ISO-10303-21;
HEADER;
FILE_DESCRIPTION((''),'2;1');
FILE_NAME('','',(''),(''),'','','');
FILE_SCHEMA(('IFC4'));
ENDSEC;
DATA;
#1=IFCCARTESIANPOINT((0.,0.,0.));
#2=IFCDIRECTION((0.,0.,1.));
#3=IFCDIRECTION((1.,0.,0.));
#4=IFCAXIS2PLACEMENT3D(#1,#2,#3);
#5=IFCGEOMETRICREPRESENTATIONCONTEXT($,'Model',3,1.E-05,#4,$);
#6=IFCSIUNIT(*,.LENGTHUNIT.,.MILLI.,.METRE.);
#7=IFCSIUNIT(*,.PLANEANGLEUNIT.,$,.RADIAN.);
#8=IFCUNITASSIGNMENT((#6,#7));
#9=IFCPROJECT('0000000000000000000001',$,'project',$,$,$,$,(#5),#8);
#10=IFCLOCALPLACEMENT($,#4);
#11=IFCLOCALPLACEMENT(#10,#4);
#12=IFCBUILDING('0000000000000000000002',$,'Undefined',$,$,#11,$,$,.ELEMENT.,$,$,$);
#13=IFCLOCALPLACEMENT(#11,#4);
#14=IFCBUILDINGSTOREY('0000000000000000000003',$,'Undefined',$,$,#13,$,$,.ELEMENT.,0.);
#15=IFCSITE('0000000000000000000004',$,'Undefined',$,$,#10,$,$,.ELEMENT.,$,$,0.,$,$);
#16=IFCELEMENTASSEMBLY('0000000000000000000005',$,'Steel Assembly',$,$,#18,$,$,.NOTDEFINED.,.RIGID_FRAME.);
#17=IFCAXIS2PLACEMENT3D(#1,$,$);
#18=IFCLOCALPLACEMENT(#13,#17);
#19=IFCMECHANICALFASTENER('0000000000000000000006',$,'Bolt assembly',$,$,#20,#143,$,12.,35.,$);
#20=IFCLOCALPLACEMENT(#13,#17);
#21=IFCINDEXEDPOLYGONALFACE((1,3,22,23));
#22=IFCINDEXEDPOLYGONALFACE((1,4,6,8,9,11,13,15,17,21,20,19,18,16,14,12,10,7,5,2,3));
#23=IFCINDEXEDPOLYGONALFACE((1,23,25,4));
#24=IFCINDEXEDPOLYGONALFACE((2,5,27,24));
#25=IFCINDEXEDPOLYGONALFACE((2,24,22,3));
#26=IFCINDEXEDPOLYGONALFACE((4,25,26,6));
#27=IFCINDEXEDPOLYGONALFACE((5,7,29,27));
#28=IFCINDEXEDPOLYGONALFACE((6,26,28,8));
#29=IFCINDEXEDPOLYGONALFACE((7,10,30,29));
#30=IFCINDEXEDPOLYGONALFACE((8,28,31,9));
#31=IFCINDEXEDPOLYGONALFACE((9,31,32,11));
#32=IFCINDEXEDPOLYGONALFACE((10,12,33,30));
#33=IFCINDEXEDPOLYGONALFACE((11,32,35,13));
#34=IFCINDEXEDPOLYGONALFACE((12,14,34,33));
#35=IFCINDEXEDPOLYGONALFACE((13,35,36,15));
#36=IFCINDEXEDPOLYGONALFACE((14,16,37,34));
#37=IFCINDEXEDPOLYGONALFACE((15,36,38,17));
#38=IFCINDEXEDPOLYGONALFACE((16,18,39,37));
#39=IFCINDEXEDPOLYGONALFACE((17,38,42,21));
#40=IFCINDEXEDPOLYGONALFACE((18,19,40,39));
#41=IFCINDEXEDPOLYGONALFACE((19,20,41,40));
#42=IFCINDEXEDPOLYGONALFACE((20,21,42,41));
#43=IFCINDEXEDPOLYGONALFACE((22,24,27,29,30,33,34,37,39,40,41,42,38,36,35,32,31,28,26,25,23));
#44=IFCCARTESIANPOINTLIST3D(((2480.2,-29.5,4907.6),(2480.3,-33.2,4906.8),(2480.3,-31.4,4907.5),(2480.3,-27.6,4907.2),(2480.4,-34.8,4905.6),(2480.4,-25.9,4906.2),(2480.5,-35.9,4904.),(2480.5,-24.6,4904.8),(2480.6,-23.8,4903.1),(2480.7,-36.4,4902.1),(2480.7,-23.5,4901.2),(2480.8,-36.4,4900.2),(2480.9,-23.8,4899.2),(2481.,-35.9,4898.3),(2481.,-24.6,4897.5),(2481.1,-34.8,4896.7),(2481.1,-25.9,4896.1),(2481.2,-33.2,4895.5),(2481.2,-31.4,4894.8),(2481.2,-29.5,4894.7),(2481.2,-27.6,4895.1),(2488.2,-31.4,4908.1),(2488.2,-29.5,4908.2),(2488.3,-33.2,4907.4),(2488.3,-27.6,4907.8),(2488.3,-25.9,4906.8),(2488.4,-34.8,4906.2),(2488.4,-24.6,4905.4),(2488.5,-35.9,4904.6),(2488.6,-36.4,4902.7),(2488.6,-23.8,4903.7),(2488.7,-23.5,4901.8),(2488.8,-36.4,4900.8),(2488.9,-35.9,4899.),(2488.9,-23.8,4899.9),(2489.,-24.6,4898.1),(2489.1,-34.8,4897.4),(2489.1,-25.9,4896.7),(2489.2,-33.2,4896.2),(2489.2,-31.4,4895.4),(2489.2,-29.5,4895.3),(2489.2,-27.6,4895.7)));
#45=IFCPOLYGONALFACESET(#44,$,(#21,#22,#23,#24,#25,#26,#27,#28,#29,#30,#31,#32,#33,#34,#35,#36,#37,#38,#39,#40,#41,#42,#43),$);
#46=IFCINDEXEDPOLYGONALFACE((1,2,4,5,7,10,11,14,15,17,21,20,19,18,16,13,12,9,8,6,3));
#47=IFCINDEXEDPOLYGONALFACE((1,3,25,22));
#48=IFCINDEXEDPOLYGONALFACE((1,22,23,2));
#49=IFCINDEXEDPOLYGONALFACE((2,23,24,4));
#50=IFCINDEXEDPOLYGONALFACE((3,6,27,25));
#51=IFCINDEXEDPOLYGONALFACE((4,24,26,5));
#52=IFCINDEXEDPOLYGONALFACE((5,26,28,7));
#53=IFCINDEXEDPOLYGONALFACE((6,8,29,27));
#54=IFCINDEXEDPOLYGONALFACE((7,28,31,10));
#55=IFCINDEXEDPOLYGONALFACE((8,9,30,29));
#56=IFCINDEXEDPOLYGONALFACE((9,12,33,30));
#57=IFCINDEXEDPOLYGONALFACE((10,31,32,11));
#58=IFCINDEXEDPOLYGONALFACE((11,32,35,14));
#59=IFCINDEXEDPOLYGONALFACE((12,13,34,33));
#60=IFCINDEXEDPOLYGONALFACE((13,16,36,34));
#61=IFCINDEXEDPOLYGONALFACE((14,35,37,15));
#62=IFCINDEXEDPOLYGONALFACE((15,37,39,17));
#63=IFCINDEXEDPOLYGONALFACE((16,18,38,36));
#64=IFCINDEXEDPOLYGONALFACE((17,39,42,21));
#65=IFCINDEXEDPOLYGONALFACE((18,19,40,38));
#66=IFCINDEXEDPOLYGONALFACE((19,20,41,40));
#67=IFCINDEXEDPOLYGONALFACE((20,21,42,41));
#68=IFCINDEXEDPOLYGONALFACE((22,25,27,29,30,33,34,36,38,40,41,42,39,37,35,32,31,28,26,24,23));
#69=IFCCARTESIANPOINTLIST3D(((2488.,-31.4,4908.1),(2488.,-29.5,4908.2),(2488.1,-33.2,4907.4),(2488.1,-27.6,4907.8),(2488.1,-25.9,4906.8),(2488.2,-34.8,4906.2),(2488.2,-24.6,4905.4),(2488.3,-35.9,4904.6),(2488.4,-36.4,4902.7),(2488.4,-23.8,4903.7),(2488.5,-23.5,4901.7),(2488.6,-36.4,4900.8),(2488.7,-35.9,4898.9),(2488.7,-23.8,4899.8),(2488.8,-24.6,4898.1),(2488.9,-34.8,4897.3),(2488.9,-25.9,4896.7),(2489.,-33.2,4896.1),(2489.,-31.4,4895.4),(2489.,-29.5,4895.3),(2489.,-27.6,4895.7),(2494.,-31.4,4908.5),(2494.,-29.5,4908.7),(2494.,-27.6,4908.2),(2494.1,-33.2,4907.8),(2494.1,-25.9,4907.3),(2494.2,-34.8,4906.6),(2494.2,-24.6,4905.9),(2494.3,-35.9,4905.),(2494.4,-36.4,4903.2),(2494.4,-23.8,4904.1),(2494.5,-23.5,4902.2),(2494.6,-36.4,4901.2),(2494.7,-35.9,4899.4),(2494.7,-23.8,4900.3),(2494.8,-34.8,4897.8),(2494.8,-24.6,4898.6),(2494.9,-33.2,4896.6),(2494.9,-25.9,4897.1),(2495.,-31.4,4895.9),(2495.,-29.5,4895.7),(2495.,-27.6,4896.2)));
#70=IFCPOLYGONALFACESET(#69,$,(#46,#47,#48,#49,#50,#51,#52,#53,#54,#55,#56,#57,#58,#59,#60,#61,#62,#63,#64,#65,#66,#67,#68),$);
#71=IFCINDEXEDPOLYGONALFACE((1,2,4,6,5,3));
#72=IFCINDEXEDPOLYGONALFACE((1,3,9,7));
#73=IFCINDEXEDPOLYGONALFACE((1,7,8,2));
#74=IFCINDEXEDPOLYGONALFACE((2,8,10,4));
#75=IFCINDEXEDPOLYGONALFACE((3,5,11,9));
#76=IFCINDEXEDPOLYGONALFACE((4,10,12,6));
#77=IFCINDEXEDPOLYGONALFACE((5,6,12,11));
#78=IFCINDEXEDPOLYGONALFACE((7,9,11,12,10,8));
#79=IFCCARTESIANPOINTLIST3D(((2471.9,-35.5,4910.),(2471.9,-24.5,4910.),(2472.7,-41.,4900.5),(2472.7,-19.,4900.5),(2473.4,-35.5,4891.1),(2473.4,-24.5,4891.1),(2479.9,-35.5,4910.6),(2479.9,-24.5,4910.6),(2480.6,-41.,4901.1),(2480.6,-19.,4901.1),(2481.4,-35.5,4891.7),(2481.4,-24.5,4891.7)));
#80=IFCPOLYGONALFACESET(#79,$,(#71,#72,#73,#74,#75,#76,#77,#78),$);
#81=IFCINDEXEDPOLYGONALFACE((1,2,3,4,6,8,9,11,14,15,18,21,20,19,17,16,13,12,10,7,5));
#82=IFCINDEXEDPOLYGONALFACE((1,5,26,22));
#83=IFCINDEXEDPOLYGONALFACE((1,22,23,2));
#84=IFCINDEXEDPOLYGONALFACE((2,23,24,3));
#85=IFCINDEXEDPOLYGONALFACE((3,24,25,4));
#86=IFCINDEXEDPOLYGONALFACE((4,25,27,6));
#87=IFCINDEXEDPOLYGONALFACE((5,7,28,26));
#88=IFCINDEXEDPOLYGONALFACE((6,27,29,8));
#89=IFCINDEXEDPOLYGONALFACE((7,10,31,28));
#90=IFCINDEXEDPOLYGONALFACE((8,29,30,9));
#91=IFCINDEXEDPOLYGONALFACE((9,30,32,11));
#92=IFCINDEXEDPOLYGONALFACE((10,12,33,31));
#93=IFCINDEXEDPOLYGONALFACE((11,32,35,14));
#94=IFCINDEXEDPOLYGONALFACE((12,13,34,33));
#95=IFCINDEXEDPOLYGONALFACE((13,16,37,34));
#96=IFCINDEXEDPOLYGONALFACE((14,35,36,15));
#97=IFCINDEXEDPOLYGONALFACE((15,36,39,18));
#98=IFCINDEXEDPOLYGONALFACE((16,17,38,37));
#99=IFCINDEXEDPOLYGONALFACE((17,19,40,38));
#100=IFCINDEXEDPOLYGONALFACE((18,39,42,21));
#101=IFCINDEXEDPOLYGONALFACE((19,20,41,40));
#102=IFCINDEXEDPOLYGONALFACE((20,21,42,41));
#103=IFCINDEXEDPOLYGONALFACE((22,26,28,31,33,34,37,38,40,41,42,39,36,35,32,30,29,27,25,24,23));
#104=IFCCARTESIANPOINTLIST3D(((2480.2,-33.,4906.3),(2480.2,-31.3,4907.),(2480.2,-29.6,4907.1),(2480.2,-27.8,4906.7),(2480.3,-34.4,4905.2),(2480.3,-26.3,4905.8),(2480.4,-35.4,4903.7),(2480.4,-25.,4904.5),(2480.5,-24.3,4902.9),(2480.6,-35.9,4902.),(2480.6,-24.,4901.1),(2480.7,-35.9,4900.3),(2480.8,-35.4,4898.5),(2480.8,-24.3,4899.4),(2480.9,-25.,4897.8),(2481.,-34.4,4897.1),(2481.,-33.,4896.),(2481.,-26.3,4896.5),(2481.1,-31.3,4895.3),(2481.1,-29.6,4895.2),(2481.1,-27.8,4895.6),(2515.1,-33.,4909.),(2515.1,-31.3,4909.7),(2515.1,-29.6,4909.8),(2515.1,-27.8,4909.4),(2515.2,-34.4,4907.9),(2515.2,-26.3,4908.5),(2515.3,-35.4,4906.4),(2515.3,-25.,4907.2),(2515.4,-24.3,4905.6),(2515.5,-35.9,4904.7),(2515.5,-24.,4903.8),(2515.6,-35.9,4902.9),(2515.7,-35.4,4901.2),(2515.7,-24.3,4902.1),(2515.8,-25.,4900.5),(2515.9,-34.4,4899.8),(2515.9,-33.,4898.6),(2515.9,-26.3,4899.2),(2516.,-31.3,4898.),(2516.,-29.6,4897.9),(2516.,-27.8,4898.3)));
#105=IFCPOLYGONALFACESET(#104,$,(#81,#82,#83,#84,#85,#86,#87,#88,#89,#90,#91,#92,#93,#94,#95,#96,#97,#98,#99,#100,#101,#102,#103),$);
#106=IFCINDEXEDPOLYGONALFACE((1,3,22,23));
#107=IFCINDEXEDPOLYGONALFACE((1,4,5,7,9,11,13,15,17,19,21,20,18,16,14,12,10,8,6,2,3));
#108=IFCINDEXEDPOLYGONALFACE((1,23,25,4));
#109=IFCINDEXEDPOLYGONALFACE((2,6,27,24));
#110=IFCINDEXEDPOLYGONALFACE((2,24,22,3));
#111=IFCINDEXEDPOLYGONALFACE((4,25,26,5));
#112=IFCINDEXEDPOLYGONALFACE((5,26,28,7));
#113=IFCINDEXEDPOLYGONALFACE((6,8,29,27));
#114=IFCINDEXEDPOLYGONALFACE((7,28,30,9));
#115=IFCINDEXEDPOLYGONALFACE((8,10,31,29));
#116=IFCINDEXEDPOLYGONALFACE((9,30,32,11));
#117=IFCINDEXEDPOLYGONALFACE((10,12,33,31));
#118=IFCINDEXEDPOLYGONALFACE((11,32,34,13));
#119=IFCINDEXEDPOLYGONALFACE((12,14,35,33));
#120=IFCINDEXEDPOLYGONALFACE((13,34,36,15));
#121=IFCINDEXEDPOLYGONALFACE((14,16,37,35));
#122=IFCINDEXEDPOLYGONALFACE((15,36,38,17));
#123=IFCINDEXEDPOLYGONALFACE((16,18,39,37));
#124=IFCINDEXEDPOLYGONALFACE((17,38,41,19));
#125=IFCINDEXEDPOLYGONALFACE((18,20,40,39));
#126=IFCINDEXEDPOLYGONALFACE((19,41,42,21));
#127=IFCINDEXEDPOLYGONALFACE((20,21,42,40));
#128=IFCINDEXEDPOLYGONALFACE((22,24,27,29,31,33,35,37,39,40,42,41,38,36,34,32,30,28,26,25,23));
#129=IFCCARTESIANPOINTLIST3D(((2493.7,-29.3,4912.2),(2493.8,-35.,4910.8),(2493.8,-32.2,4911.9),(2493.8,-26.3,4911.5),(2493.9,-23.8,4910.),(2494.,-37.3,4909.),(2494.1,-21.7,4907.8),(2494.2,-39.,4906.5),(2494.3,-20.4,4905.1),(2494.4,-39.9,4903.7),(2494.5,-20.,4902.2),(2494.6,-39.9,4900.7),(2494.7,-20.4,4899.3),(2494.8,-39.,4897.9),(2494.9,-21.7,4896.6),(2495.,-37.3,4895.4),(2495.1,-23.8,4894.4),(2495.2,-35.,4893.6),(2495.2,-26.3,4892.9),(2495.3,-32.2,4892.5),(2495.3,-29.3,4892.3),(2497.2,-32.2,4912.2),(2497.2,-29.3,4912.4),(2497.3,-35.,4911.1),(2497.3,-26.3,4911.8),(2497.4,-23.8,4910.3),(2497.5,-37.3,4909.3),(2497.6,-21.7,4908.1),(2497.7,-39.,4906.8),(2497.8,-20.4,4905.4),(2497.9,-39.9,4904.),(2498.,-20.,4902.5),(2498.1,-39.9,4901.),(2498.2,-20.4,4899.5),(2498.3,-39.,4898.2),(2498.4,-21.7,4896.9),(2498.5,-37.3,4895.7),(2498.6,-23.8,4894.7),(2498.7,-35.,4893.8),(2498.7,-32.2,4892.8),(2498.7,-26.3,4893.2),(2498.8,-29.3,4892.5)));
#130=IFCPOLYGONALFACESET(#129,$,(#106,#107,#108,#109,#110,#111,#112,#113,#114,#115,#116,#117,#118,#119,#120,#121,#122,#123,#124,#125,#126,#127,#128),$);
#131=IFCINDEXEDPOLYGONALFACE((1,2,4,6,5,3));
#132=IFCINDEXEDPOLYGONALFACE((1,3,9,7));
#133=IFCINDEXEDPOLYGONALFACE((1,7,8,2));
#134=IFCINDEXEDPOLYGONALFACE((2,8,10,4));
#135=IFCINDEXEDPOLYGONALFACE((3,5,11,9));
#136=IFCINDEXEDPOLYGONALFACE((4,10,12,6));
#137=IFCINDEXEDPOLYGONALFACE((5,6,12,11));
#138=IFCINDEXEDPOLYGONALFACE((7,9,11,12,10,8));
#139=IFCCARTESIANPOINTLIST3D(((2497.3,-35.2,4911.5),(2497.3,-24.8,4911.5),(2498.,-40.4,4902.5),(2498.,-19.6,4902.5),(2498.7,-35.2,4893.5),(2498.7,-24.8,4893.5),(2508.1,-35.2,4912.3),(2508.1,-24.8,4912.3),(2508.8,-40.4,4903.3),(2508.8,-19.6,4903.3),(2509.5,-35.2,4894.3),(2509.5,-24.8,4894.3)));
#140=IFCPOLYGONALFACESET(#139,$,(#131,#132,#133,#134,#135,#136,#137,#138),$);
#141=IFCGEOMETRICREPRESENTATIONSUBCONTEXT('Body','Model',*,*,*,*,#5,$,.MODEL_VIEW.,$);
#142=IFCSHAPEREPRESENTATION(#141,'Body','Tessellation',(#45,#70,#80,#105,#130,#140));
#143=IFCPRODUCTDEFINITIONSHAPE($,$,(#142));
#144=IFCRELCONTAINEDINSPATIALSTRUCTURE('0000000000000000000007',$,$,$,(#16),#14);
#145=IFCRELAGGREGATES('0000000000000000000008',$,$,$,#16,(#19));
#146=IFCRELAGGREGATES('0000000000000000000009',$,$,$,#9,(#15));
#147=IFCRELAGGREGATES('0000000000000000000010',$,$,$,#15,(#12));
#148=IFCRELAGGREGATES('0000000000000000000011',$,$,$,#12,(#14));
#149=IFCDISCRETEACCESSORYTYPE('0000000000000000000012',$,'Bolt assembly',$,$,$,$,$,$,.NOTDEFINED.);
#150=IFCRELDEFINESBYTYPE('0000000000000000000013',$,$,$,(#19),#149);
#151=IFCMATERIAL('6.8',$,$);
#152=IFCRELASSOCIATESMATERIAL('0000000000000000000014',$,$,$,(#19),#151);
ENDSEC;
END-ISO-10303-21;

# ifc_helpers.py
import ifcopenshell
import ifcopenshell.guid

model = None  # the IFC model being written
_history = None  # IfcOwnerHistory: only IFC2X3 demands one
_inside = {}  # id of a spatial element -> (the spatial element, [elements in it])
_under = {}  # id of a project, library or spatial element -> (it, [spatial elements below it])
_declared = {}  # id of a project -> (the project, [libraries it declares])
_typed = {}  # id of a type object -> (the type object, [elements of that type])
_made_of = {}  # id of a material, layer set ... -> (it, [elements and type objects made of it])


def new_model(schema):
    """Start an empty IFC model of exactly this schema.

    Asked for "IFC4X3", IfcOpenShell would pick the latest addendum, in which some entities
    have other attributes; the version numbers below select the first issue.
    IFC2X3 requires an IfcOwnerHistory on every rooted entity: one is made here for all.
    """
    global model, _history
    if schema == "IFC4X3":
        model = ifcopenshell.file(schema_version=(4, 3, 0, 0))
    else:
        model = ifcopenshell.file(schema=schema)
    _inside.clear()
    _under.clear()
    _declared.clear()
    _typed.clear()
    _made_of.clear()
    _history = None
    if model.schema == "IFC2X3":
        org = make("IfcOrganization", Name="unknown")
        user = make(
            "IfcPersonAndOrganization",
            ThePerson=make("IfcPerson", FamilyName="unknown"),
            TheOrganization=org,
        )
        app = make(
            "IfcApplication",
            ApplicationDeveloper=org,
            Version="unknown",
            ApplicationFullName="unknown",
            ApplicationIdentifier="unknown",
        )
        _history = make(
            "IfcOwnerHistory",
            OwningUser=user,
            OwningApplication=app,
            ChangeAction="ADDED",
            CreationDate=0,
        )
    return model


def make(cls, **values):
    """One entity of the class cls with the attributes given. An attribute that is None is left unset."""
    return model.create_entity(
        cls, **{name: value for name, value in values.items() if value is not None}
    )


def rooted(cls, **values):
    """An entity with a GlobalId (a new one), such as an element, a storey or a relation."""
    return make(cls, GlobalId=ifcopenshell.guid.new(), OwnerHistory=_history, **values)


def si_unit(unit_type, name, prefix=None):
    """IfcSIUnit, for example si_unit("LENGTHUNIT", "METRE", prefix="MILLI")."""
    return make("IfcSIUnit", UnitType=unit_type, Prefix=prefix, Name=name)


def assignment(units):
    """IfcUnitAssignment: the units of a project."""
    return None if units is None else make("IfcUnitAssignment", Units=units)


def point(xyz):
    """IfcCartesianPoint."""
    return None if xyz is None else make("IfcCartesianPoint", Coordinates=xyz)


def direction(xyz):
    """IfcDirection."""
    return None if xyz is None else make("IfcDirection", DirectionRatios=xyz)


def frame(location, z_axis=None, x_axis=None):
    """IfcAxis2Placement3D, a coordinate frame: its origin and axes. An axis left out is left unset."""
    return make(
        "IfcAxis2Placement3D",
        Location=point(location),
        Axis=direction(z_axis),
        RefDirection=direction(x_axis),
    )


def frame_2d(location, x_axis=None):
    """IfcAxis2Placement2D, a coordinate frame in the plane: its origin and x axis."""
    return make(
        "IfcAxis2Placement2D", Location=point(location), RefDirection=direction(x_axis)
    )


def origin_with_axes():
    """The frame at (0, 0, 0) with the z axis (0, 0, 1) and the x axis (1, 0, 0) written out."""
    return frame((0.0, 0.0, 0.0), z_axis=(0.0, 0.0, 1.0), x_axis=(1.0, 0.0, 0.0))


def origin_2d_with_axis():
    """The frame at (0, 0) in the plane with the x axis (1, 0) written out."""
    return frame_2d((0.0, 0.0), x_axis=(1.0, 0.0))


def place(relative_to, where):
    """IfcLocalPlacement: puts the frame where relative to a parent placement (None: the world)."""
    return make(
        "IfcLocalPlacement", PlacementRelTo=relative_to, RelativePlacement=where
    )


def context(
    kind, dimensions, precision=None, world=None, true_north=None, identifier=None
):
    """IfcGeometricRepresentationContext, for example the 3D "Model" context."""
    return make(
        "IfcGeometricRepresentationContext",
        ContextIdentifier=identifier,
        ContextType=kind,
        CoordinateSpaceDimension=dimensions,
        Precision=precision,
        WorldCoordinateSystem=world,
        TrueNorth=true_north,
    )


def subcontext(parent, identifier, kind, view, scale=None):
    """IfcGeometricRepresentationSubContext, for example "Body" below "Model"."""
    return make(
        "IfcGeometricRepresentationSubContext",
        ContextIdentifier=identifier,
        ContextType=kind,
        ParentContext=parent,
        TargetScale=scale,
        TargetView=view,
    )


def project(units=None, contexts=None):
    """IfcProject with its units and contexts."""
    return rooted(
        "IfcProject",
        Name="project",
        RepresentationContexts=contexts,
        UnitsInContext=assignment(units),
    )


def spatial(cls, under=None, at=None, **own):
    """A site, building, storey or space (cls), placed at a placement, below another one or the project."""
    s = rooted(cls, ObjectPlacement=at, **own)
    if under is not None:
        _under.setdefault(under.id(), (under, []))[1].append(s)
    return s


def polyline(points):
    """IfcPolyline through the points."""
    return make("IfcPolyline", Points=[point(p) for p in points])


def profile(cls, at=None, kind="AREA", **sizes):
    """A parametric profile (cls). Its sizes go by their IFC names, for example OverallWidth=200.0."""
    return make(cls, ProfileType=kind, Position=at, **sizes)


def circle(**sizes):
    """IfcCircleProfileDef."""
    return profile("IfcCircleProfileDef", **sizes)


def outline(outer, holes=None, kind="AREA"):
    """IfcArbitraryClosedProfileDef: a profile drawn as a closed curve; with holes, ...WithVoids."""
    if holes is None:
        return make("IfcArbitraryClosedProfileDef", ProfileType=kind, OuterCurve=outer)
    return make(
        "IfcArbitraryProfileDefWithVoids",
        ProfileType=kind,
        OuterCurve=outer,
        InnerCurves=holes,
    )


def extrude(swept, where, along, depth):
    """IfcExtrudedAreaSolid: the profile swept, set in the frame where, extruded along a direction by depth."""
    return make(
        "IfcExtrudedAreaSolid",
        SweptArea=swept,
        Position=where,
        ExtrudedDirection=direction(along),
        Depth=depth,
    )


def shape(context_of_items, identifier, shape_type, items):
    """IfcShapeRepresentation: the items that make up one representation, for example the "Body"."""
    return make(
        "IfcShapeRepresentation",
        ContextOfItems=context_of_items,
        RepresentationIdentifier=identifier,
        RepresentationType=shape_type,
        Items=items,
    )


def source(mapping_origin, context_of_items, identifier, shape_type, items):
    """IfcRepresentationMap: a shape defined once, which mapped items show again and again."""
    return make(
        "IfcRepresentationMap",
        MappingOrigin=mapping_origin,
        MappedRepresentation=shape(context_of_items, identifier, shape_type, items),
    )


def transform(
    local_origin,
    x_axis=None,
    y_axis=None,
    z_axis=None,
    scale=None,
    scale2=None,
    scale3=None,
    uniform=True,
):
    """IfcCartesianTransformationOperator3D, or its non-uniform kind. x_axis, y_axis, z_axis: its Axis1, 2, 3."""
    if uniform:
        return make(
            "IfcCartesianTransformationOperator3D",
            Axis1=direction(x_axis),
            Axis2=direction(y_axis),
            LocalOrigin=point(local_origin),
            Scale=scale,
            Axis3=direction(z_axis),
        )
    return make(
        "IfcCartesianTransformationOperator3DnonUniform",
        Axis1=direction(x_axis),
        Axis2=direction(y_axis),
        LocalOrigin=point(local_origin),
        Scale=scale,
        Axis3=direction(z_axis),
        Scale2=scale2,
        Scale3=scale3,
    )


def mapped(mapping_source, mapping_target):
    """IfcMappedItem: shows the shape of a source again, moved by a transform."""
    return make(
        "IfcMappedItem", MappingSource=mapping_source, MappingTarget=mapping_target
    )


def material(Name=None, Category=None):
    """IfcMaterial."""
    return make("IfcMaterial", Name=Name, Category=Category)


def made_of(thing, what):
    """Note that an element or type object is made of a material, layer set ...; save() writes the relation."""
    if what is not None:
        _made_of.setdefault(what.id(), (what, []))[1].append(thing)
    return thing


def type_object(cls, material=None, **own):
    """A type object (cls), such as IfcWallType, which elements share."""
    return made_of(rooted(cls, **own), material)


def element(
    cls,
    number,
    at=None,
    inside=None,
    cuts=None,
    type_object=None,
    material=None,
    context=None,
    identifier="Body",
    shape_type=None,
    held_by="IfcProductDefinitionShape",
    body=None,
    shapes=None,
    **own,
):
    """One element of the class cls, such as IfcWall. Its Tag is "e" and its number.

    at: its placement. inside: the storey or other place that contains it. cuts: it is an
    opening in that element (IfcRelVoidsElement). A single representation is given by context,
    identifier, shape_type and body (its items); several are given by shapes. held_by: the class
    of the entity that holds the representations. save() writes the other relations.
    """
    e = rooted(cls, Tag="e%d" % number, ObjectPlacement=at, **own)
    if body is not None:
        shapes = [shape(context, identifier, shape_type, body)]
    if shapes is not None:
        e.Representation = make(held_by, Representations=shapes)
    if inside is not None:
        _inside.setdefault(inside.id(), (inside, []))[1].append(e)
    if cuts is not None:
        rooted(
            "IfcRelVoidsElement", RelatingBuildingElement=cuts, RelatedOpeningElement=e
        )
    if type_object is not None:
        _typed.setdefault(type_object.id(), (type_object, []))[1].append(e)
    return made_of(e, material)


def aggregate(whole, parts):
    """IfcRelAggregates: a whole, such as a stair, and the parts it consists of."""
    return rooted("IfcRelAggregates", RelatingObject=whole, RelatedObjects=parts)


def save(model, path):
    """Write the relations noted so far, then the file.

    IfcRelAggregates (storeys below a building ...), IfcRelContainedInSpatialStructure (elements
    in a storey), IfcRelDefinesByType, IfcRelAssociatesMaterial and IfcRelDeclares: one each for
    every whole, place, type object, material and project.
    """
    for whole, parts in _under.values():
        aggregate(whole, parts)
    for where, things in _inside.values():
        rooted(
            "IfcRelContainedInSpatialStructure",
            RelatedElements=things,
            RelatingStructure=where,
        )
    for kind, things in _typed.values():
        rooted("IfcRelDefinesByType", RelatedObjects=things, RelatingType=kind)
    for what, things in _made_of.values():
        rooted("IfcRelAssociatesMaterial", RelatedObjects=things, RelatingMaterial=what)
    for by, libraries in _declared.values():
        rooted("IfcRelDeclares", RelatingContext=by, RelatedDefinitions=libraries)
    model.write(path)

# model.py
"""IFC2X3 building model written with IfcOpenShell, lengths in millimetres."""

from ifc_helpers import new_model, si_unit, frame, origin_with_axes, origin_2d_with_axis, place, context, subcontext, project, spatial, polyline, circle, outline, extrude, source, transform, mapped, material, type_object, element, aggregate, save


model = new_model("IFC2X3")

# Units and contexts
model_context = context("Model", 3, precision=1e-05, world=origin_with_axes())
body_context = subcontext(model_context, "Body", "Model", "MODEL_VIEW")
ifc_project = project(units=[si_unit("LENGTHUNIT", "METRE", prefix="MILLI"), si_unit("PLANEANGLEUNIT", "RADIAN")], contexts=[model_context])

# Site, building, storey
site_placement = place(None, origin_with_axes())
site = spatial("IfcSite", under=ifc_project, at=site_placement, Name="Undefined", CompositionType="ELEMENT", RefElevation=0.0)
building_placement = place(site_placement, origin_with_axes())
building = spatial("IfcBuilding", under=site, at=building_placement, Name="Undefined", CompositionType="ELEMENT")
storey_placement = place(building_placement, origin_with_axes())
storey = spatial("IfcBuildingStorey", under=building, at=storey_placement, Name="Undefined", CompositionType="ELEMENT", Elevation=0.0)

# Element assembly, mechanical fastener
ifc_material_1 = material(Name="6.8")
discrete_accessory_type_1 = type_object("IfcDiscreteAccessoryType", Name="Bolt assembly")
assembly_1_placement = place(storey_placement, origin_with_axes())
assembly_1 = element("IfcElementAssembly", 1, at=assembly_1_placement, inside=storey, Name="Steel Assembly", AssemblyPlace="NOTDEFINED", PredefinedType="RIGID_FRAME")
shared_shape_1 = source(origin_with_axes(), body_context, "Body", "SweptSolid", [
    extrude(circle(Radius=6.5, at=origin_2d_with_axis()), frame((0.0, -10.9, 0.0), z_axis=(0.0, 1.0, 0.0), x_axis=(1.0, 0.0, 0.0)), (0.0, 0.0, 1.0), 8.0),
    extrude(circle(Radius=6.5, at=origin_2d_with_axis()), frame((0.0, -3.1, 0.0), z_axis=(0.0, 1.0, 0.0), x_axis=(1.0, 0.0, 0.0)), (0.0, 0.0, 1.0), 6.0),
    extrude(outline(polyline([(11.0, 0.0), (5.5, 9.5), (-5.5, 9.5), (-11.0, 0.0), (-5.5, -9.5), (5.5, -9.5), (11.0, 0.0)])), frame((0.0, -19.0, 0.0), z_axis=(0.0, 1.0, 0.0), x_axis=(1.0, 0.0, 0.0)), (0.0, 0.0, 1.0), 8.0),
    extrude(circle(Radius=6.0, at=origin_2d_with_axis()), frame((0.0, -11.0, 0.0), z_axis=(0.0, 1.0, 0.0), x_axis=(1.0, 0.0, 0.0)), (0.0, 0.0, 1.0), 35.0),
    extrude(circle(Radius=10.0, at=origin_2d_with_axis()), frame((0.0, 3.0, 0.0), z_axis=(0.0, 1.0, 0.0), x_axis=(1.0, 0.0, 0.0)), (0.0, 0.0, 1.0), 3.5),
    extrude(outline(polyline([(10.4, 0.0), (5.2, 9.0), (-5.2, 9.0), (-10.4, 0.0), (-5.2, -9.0), (5.2, -9.0), (10.4, 0.0)])), frame((0.0, 6.5, 0.0), z_axis=(0.0, 1.0, 0.0), x_axis=(1.0, 0.0, 0.0)), (0.0, 0.0, 1.0), 10.8),
])
mechanical_fastener_1_placement = place(assembly_1_placement, frame((2491.6, -30.0, 4902.0), z_axis=(0.076696, 0.0, -0.997054), x_axis=(0.0, 1.0, 0.0)))
mechanical_fastener_1 = element("IfcMechanicalFastener", 2, at=mechanical_fastener_1_placement, type_object=discrete_accessory_type_1, material=ifc_material_1, Name="Bolt assembly", NominalDiameter=12.0, NominalLength=35.0, context=body_context, shape_type="MappedRepresentation", body=[
    mapped(shared_shape_1, transform((0.0, 0.0, 0.0))),
])
aggregate(assembly_1, [mechanical_fastener_1])

save(model, "model.ifc")
